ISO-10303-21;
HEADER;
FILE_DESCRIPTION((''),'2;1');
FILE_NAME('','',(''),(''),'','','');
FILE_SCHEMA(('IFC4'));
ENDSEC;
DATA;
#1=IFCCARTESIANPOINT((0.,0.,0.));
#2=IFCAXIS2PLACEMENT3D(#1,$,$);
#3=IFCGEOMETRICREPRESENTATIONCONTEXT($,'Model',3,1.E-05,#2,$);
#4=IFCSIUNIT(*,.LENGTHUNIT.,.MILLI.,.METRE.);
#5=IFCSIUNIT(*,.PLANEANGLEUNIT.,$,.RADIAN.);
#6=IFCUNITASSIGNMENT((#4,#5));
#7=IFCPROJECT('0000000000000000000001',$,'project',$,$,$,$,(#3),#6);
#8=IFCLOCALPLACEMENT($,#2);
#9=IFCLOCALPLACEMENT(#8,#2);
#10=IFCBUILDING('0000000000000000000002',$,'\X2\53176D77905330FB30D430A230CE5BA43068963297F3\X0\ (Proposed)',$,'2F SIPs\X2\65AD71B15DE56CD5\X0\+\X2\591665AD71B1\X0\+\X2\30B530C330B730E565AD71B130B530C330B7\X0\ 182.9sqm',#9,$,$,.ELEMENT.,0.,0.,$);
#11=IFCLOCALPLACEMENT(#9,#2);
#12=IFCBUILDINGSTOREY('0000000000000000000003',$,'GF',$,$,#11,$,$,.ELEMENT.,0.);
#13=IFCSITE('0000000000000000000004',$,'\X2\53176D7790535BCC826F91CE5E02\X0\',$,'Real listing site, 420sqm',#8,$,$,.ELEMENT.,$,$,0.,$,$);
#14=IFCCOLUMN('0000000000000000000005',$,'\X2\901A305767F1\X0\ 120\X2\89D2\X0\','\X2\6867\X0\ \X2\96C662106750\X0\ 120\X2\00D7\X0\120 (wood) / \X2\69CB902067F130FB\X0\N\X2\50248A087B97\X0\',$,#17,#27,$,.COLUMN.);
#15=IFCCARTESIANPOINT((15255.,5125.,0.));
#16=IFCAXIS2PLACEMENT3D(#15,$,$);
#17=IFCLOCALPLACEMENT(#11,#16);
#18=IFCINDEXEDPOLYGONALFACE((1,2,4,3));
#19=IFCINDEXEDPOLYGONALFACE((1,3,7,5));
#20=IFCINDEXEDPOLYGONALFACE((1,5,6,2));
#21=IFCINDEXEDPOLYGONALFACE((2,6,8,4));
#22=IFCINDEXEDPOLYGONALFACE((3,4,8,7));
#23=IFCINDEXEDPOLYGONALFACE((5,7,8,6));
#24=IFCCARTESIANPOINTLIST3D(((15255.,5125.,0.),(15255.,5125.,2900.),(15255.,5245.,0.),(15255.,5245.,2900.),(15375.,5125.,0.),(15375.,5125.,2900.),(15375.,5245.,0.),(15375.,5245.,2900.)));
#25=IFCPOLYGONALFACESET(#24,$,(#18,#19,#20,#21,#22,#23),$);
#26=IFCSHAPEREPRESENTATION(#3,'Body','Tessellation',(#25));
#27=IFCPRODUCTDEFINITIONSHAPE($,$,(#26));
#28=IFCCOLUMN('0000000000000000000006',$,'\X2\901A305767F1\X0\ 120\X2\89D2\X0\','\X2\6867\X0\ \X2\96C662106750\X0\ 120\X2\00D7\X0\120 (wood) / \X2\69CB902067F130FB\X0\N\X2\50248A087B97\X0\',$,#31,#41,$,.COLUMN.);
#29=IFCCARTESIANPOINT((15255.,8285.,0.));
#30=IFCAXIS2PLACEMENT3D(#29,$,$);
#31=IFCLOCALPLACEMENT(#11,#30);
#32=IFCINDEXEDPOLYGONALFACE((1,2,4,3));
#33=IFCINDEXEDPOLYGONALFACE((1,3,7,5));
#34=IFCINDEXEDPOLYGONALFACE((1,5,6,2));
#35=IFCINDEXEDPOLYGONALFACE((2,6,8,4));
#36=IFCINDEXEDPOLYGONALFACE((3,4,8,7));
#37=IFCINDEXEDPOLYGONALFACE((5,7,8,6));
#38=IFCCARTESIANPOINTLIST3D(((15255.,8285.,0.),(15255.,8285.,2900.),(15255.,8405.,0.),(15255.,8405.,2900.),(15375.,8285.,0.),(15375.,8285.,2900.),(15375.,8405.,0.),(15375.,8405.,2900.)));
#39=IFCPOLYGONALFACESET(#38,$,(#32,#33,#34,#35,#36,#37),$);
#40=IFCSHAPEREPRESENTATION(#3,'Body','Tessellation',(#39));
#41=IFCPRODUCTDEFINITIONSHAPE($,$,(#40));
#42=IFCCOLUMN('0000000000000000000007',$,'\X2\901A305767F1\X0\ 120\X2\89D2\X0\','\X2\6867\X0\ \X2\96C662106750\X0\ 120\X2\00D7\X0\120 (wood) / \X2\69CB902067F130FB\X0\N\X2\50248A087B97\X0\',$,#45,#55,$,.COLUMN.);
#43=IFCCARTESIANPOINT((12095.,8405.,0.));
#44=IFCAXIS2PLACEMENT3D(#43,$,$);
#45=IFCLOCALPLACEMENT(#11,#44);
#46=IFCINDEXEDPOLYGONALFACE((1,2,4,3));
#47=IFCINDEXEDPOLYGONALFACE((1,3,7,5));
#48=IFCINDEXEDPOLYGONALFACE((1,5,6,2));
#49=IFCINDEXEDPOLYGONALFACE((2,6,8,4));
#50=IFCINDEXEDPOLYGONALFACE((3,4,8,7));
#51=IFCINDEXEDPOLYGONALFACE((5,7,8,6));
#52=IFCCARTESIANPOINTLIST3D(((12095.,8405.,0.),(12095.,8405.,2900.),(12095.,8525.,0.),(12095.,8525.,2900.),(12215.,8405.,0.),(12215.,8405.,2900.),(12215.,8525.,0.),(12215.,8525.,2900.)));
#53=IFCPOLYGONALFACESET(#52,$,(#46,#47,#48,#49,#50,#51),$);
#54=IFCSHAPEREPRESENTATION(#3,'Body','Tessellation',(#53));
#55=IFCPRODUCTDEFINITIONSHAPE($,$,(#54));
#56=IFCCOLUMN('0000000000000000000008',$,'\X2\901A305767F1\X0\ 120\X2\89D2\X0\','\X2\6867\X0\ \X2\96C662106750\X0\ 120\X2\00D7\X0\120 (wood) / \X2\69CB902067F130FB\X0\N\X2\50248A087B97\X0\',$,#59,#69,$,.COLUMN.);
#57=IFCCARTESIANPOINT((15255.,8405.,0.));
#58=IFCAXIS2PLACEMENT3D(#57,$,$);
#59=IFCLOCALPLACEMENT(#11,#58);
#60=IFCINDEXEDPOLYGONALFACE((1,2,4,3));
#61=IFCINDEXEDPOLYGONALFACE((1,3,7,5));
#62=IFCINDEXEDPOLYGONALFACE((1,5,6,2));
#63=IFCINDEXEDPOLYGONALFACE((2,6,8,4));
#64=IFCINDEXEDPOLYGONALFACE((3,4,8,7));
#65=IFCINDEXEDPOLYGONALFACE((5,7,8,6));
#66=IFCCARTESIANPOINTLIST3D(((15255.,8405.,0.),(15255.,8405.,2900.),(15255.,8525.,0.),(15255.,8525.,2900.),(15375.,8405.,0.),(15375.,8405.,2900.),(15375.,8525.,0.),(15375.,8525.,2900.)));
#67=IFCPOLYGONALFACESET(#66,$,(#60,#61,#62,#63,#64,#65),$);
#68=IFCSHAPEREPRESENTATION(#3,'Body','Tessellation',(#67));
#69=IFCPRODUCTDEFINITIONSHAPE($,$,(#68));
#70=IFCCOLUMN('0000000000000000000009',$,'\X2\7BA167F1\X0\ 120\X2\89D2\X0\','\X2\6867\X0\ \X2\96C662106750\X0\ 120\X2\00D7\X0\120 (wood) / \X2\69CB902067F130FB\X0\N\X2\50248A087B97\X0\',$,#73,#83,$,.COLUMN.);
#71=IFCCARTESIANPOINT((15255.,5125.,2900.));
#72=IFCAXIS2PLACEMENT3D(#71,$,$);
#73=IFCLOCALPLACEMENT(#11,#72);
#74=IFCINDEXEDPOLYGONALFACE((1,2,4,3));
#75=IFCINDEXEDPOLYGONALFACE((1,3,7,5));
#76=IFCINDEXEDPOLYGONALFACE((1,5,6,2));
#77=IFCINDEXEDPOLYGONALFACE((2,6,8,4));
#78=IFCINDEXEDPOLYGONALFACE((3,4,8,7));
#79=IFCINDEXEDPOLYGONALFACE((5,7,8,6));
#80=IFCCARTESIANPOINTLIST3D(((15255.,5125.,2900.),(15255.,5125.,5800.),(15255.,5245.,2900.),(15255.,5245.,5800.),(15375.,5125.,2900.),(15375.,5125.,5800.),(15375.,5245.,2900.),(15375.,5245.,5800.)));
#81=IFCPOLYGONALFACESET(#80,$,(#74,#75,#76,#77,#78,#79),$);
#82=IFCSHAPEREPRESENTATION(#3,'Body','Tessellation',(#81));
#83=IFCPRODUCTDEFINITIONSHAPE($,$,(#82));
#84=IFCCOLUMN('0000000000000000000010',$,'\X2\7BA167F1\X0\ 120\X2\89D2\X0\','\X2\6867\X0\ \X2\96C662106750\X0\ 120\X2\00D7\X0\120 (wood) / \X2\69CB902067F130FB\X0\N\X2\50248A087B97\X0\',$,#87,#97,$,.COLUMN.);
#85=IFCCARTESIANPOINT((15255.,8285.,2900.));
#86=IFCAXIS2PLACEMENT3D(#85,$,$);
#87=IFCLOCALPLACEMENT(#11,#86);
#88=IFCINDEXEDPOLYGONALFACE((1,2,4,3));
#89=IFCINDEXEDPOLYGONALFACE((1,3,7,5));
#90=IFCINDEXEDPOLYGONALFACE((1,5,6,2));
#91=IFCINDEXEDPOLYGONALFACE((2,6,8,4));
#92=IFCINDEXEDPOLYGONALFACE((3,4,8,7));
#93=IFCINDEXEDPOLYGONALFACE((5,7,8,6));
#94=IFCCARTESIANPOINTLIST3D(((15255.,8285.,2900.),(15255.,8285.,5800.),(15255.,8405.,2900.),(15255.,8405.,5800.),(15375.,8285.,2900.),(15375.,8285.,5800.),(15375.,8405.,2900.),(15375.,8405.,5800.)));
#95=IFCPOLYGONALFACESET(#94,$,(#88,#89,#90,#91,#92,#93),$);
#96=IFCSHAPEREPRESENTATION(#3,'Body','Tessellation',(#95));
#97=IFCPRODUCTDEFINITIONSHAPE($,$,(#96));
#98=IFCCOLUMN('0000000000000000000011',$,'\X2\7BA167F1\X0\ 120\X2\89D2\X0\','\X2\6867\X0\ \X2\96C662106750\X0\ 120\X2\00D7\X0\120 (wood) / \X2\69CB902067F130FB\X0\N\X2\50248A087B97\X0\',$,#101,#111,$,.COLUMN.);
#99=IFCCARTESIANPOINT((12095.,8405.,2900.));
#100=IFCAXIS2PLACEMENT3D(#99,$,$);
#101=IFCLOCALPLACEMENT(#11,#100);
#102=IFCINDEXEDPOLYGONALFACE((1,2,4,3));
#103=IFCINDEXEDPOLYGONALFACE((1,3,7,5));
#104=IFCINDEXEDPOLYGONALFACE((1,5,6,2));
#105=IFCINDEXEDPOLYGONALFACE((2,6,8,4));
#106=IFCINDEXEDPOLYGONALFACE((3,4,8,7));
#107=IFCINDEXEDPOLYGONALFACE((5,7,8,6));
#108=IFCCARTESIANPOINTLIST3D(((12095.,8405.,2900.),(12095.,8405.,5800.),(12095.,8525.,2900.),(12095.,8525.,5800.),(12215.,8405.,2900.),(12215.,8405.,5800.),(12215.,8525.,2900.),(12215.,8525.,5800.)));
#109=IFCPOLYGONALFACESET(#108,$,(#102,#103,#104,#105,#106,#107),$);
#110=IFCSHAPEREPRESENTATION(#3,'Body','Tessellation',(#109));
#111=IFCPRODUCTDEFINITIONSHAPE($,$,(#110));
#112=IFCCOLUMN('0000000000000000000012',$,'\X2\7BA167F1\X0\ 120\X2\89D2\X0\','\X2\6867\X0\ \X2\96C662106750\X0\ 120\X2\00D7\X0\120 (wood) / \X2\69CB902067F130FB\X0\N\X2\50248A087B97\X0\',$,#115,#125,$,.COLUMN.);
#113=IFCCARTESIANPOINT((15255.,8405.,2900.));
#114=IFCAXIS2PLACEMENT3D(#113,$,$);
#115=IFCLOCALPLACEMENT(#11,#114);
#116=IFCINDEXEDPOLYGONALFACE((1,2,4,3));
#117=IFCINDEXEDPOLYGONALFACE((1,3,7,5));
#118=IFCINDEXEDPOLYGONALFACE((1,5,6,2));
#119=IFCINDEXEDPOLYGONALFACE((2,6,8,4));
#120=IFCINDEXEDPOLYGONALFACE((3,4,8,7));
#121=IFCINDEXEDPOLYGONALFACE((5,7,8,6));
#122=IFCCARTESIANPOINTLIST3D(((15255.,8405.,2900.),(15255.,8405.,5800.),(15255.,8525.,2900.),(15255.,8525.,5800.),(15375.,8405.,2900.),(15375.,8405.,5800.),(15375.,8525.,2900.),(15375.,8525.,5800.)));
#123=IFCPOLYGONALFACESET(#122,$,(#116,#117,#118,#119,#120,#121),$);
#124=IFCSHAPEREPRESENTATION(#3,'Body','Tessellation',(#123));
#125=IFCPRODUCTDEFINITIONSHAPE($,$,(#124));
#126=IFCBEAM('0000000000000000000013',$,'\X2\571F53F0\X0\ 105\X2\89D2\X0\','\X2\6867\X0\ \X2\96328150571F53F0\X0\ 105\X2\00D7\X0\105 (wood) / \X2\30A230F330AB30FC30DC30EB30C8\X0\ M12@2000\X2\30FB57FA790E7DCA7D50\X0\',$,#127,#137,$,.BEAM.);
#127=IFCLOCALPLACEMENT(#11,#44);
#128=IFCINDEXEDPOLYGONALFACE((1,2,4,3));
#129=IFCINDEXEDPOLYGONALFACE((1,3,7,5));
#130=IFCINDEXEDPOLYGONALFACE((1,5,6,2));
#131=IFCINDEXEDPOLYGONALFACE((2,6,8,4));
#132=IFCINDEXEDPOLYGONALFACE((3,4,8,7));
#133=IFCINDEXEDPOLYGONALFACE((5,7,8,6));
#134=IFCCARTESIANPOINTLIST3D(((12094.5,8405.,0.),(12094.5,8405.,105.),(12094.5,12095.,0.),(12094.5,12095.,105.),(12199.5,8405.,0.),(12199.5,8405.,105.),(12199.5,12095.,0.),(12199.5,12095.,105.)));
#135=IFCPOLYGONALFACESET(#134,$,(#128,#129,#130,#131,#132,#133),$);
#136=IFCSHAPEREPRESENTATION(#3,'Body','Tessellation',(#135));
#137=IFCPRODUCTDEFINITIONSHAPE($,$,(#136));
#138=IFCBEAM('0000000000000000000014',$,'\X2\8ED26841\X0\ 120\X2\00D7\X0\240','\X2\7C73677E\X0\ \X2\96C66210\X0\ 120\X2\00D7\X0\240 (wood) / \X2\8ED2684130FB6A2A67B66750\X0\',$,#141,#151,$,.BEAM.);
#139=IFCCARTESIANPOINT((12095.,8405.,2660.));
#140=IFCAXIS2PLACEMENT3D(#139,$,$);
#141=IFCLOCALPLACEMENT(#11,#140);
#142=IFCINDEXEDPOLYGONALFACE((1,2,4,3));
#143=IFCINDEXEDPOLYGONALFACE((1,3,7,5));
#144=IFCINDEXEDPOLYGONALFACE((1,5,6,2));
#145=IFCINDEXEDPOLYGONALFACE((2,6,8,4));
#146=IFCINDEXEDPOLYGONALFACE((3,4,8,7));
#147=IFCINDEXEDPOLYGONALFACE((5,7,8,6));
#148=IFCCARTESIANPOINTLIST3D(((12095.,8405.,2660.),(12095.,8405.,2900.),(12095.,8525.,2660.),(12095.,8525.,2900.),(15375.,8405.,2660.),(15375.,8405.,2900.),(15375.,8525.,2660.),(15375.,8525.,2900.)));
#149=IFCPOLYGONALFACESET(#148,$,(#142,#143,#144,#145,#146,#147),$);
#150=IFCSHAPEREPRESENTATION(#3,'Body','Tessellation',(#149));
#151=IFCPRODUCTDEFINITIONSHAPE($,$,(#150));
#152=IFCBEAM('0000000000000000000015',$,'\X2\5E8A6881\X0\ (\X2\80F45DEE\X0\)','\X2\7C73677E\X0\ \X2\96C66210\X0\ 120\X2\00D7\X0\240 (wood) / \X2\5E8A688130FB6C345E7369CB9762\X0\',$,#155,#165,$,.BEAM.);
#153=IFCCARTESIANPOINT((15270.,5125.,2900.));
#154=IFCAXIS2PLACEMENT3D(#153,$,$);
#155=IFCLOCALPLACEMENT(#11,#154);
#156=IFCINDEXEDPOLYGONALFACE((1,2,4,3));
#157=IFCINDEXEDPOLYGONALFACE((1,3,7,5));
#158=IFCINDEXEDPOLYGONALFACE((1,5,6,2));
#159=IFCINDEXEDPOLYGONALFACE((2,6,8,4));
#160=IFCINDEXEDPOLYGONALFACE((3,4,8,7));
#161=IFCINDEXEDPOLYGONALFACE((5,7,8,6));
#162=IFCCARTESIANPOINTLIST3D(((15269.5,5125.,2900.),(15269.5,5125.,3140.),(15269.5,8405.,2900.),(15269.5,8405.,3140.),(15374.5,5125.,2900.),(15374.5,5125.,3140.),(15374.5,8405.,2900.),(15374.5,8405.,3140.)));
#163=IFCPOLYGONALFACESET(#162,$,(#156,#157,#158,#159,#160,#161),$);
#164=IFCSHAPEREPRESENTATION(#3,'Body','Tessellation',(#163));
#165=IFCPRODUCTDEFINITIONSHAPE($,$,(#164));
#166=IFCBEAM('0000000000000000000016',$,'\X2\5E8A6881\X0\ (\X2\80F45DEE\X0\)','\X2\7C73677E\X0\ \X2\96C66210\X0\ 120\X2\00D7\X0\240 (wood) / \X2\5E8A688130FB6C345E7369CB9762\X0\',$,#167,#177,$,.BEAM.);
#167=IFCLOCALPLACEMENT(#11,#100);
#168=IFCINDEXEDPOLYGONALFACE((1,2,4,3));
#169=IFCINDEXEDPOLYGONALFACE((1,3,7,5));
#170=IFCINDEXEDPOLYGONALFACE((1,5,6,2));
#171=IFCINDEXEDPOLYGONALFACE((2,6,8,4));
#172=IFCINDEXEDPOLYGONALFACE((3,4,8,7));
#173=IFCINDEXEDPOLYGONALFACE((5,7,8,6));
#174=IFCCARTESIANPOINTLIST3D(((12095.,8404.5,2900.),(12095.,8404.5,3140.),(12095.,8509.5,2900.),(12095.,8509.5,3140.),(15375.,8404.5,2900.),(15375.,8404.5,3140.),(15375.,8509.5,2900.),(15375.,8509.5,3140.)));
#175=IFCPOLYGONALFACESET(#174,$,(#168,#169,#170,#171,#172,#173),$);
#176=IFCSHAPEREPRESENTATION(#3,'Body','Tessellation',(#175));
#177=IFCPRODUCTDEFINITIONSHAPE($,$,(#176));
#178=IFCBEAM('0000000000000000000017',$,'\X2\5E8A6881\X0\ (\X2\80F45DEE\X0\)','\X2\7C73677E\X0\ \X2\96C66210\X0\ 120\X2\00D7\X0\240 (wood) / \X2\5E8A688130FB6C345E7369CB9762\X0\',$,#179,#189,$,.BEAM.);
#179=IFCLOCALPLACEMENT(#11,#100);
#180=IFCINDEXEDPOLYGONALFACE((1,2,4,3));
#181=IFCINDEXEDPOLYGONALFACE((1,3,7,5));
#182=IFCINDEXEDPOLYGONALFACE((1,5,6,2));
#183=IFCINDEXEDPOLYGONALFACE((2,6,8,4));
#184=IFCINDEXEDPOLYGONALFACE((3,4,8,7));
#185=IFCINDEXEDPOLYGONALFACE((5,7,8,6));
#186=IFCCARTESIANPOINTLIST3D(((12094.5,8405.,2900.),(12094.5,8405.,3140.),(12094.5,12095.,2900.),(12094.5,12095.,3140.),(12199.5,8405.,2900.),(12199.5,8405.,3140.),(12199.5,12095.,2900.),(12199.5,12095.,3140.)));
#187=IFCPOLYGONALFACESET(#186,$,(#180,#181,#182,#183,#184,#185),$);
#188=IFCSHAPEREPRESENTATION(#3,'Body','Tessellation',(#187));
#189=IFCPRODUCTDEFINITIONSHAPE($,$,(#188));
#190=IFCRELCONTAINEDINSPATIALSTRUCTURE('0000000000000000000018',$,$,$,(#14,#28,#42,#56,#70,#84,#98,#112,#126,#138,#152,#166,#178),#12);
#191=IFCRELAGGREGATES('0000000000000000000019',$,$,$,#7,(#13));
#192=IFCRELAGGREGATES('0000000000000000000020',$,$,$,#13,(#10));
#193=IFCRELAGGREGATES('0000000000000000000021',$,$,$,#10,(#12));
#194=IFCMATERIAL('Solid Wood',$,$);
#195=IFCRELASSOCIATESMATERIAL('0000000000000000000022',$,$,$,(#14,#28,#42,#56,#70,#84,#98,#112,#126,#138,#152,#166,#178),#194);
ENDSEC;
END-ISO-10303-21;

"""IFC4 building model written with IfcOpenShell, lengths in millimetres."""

from ifc_helpers import new_model, si_unit, frame, frame_2d, origin, place, context, project, spatial, rectangle, extrude, material, element, save


model = new_model("IFC4")

# Units and contexts
model_context = context("Model", 3, precision=1e-05, world=origin())
ifc_project = project(units=[si_unit("LENGTHUNIT", "METRE", prefix="MILLI"), si_unit("PLANEANGLEUNIT", "RADIAN")], contexts=[model_context])

# Site, building, storey
site_placement = place(None, origin())
site = spatial("IfcSite", under=ifc_project, at=site_placement, Name="北海道富良野市", ObjectType="Real listing site, 420sqm", CompositionType="ELEMENT", RefElevation=0.0)
building_placement = place(site_placement, origin())
building = spatial("IfcBuilding", under=site, at=building_placement, Name="北海道・ピアノ室と防音 (Proposed)", ObjectType="2F SIPs断熱工法+外断熱+サッシュ断熱サッシ 182.9sqm", CompositionType="ELEMENT", ElevationOfRefHeight=0.0, ElevationOfTerrain=0.0)
storey_placement = place(building_placement, origin())
storey = spatial("IfcBuildingStorey", under=building, at=storey_placement, Name="GF", CompositionType="ELEMENT", Elevation=0.0)

# Columns
ifc_material_1 = material(Name="Solid Wood")
column_1_placement = place(storey_placement, frame((15255.0, 5125.0, 0.0)))
element("IfcColumn", 1, at=column_1_placement, inside=storey, material=ifc_material_1, Name="通し柱 120角", Description="桧 集成材 120×120 (wood) / 構造柱・N値計算", PredefinedType="COLUMN", context=model_context, shape_type="SweptSolid", body=[
    extrude(rectangle(XDim=120.0, YDim=120.0, at=frame_2d((60.0, 60.0))), frame((15255.0, 5125.0, 0.0)), (0.0, 0.0, 1.0), 2900.0),
])
column_2_placement = place(storey_placement, frame((15255.0, 8285.0, 0.0)))
element("IfcColumn", 2, at=column_2_placement, inside=storey, material=ifc_material_1, Name="通し柱 120角", Description="桧 集成材 120×120 (wood) / 構造柱・N値計算", PredefinedType="COLUMN", context=model_context, shape_type="SweptSolid", body=[
    extrude(rectangle(XDim=120.0, YDim=120.0, at=frame_2d((60.0, 60.0))), frame((15255.0, 8285.0, 0.0)), (0.0, 0.0, 1.0), 2900.0),
])
column_3_placement = place(storey_placement, frame((12095.0, 8405.0, 0.0)))
element("IfcColumn", 3, at=column_3_placement, inside=storey, material=ifc_material_1, Name="通し柱 120角", Description="桧 集成材 120×120 (wood) / 構造柱・N値計算", PredefinedType="COLUMN", context=model_context, shape_type="SweptSolid", body=[
    extrude(rectangle(XDim=120.0, YDim=120.0, at=frame_2d((60.0, 60.0))), frame((12095.0, 8405.0, 0.0)), (0.0, 0.0, 1.0), 2900.0),
])
column_4_placement = place(storey_placement, frame((15255.0, 8405.0, 0.0)))
element("IfcColumn", 4, at=column_4_placement, inside=storey, material=ifc_material_1, Name="通し柱 120角", Description="桧 集成材 120×120 (wood) / 構造柱・N値計算", PredefinedType="COLUMN", context=model_context, shape_type="SweptSolid", body=[
    extrude(rectangle(XDim=120.0, YDim=120.0, at=frame_2d((60.0, 60.0))), frame((15255.0, 8405.0, 0.0)), (0.0, 0.0, 1.0), 2900.0),
])
column_5_placement = place(storey_placement, frame((15255.0, 5125.0, 2900.0)))
element("IfcColumn", 5, at=column_5_placement, inside=storey, material=ifc_material_1, Name="管柱 120角", Description="桧 集成材 120×120 (wood) / 構造柱・N値計算", PredefinedType="COLUMN", context=model_context, shape_type="SweptSolid", body=[
    extrude(rectangle(XDim=120.0, YDim=120.0, at=frame_2d((60.0, 60.0))), frame((15255.0, 5125.0, 2900.0)), (0.0, 0.0, 1.0), 2900.0),
])
column_6_placement = place(storey_placement, frame((15255.0, 8285.0, 2900.0)))
element("IfcColumn", 6, at=column_6_placement, inside=storey, material=ifc_material_1, Name="管柱 120角", Description="桧 集成材 120×120 (wood) / 構造柱・N値計算", PredefinedType="COLUMN", context=model_context, shape_type="SweptSolid", body=[
    extrude(rectangle(XDim=120.0, YDim=120.0, at=frame_2d((60.0, 60.0))), frame((15255.0, 8285.0, 2900.0)), (0.0, 0.0, 1.0), 2900.0),
])
column_7_placement = place(storey_placement, frame((12095.0, 8405.0, 2900.0)))
element("IfcColumn", 7, at=column_7_placement, inside=storey, material=ifc_material_1, Name="管柱 120角", Description="桧 集成材 120×120 (wood) / 構造柱・N値計算", PredefinedType="COLUMN", context=model_context, shape_type="SweptSolid", body=[
    extrude(rectangle(XDim=120.0, YDim=120.0, at=frame_2d((60.0, 60.0))), frame((12095.0, 8405.0, 2900.0)), (0.0, 0.0, 1.0), 2900.0),
])
column_8_placement = place(storey_placement, frame((15255.0, 8405.0, 2900.0)))
element("IfcColumn", 8, at=column_8_placement, inside=storey, material=ifc_material_1, Name="管柱 120角", Description="桧 集成材 120×120 (wood) / 構造柱・N値計算", PredefinedType="COLUMN", context=model_context, shape_type="SweptSolid", body=[
    extrude(rectangle(XDim=120.0, YDim=120.0, at=frame_2d((60.0, 60.0))), frame((15255.0, 8405.0, 2900.0)), (0.0, 0.0, 1.0), 2900.0),
])

# Beams
beam_1_placement = place(storey_placement, frame((12095.0, 8405.0, 0.0)))
element("IfcBeam", 9, at=beam_1_placement, inside=storey, material=ifc_material_1, Name="土台 105角", Description="桧 防腐土台 105×105 (wood) / アンカーボルト M12@2000・基礎緊結", PredefinedType="BEAM", context=model_context, shape_type="SweptSolid", body=[
    extrude(rectangle(XDim=105.0, YDim=3690.0, at=frame_2d((52.0, 1845.0))), frame((12095.0, 8405.0, 0.0)), (0.0, 0.0, 1.0), 105.0),
])
beam_2_placement = place(storey_placement, frame((12095.0, 8405.0, 2660.0)))
element("IfcBeam", 10, at=beam_2_placement, inside=storey, material=ifc_material_1, Name="軒桁 120×240", Description="米松 集成 120×240 (wood) / 軒桁・横架材", PredefinedType="BEAM", context=model_context, shape_type="SweptSolid", body=[
    extrude(rectangle(XDim=3280.0, YDim=120.0, at=frame_2d((1640.0, 60.0))), frame((12095.0, 8405.0, 2660.0)), (0.0, 0.0, 1.0), 240.0),
])
beam_3_placement = place(storey_placement, frame((15270.0, 5125.0, 2900.0)))
element("IfcBeam", 11, at=beam_3_placement, inside=storey, material=ifc_material_1, Name="床梁 (胴差)", Description="米松 集成 120×240 (wood) / 床梁・水平構面", PredefinedType="BEAM", context=model_context, shape_type="SweptSolid", body=[
    extrude(rectangle(XDim=105.0, YDim=3280.0, at=frame_2d((52.0, 1640.0))), frame((15270.0, 5125.0, 2900.0)), (0.0, 0.0, 1.0), 240.0),
])
beam_4_placement = place(storey_placement, frame((12095.0, 8405.0, 2900.0)))
element("IfcBeam", 12, at=beam_4_placement, inside=storey, material=ifc_material_1, Name="床梁 (胴差)", Description="米松 集成 120×240 (wood) / 床梁・水平構面", PredefinedType="BEAM", context=model_context, shape_type="SweptSolid", body=[
    extrude(rectangle(XDim=3280.0, YDim=105.0, at=frame_2d((1640.0, 52.0))), frame((12095.0, 8405.0, 2900.0)), (0.0, 0.0, 1.0), 240.0),
])
beam_5_placement = place(storey_placement, frame((12095.0, 8405.0, 2900.0)))
element("IfcBeam", 13, at=beam_5_placement, inside=storey, material=ifc_material_1, Name="床梁 (胴差)", Description="米松 集成 120×240 (wood) / 床梁・水平構面", PredefinedType="BEAM", context=model_context, shape_type="SweptSolid", body=[
    extrude(rectangle(XDim=105.0, YDim=3690.0, at=frame_2d((52.0, 1845.0))), frame((12095.0, 8405.0, 2900.0)), (0.0, 0.0, 1.0), 240.0),
])

save(model, "model.ifc")
